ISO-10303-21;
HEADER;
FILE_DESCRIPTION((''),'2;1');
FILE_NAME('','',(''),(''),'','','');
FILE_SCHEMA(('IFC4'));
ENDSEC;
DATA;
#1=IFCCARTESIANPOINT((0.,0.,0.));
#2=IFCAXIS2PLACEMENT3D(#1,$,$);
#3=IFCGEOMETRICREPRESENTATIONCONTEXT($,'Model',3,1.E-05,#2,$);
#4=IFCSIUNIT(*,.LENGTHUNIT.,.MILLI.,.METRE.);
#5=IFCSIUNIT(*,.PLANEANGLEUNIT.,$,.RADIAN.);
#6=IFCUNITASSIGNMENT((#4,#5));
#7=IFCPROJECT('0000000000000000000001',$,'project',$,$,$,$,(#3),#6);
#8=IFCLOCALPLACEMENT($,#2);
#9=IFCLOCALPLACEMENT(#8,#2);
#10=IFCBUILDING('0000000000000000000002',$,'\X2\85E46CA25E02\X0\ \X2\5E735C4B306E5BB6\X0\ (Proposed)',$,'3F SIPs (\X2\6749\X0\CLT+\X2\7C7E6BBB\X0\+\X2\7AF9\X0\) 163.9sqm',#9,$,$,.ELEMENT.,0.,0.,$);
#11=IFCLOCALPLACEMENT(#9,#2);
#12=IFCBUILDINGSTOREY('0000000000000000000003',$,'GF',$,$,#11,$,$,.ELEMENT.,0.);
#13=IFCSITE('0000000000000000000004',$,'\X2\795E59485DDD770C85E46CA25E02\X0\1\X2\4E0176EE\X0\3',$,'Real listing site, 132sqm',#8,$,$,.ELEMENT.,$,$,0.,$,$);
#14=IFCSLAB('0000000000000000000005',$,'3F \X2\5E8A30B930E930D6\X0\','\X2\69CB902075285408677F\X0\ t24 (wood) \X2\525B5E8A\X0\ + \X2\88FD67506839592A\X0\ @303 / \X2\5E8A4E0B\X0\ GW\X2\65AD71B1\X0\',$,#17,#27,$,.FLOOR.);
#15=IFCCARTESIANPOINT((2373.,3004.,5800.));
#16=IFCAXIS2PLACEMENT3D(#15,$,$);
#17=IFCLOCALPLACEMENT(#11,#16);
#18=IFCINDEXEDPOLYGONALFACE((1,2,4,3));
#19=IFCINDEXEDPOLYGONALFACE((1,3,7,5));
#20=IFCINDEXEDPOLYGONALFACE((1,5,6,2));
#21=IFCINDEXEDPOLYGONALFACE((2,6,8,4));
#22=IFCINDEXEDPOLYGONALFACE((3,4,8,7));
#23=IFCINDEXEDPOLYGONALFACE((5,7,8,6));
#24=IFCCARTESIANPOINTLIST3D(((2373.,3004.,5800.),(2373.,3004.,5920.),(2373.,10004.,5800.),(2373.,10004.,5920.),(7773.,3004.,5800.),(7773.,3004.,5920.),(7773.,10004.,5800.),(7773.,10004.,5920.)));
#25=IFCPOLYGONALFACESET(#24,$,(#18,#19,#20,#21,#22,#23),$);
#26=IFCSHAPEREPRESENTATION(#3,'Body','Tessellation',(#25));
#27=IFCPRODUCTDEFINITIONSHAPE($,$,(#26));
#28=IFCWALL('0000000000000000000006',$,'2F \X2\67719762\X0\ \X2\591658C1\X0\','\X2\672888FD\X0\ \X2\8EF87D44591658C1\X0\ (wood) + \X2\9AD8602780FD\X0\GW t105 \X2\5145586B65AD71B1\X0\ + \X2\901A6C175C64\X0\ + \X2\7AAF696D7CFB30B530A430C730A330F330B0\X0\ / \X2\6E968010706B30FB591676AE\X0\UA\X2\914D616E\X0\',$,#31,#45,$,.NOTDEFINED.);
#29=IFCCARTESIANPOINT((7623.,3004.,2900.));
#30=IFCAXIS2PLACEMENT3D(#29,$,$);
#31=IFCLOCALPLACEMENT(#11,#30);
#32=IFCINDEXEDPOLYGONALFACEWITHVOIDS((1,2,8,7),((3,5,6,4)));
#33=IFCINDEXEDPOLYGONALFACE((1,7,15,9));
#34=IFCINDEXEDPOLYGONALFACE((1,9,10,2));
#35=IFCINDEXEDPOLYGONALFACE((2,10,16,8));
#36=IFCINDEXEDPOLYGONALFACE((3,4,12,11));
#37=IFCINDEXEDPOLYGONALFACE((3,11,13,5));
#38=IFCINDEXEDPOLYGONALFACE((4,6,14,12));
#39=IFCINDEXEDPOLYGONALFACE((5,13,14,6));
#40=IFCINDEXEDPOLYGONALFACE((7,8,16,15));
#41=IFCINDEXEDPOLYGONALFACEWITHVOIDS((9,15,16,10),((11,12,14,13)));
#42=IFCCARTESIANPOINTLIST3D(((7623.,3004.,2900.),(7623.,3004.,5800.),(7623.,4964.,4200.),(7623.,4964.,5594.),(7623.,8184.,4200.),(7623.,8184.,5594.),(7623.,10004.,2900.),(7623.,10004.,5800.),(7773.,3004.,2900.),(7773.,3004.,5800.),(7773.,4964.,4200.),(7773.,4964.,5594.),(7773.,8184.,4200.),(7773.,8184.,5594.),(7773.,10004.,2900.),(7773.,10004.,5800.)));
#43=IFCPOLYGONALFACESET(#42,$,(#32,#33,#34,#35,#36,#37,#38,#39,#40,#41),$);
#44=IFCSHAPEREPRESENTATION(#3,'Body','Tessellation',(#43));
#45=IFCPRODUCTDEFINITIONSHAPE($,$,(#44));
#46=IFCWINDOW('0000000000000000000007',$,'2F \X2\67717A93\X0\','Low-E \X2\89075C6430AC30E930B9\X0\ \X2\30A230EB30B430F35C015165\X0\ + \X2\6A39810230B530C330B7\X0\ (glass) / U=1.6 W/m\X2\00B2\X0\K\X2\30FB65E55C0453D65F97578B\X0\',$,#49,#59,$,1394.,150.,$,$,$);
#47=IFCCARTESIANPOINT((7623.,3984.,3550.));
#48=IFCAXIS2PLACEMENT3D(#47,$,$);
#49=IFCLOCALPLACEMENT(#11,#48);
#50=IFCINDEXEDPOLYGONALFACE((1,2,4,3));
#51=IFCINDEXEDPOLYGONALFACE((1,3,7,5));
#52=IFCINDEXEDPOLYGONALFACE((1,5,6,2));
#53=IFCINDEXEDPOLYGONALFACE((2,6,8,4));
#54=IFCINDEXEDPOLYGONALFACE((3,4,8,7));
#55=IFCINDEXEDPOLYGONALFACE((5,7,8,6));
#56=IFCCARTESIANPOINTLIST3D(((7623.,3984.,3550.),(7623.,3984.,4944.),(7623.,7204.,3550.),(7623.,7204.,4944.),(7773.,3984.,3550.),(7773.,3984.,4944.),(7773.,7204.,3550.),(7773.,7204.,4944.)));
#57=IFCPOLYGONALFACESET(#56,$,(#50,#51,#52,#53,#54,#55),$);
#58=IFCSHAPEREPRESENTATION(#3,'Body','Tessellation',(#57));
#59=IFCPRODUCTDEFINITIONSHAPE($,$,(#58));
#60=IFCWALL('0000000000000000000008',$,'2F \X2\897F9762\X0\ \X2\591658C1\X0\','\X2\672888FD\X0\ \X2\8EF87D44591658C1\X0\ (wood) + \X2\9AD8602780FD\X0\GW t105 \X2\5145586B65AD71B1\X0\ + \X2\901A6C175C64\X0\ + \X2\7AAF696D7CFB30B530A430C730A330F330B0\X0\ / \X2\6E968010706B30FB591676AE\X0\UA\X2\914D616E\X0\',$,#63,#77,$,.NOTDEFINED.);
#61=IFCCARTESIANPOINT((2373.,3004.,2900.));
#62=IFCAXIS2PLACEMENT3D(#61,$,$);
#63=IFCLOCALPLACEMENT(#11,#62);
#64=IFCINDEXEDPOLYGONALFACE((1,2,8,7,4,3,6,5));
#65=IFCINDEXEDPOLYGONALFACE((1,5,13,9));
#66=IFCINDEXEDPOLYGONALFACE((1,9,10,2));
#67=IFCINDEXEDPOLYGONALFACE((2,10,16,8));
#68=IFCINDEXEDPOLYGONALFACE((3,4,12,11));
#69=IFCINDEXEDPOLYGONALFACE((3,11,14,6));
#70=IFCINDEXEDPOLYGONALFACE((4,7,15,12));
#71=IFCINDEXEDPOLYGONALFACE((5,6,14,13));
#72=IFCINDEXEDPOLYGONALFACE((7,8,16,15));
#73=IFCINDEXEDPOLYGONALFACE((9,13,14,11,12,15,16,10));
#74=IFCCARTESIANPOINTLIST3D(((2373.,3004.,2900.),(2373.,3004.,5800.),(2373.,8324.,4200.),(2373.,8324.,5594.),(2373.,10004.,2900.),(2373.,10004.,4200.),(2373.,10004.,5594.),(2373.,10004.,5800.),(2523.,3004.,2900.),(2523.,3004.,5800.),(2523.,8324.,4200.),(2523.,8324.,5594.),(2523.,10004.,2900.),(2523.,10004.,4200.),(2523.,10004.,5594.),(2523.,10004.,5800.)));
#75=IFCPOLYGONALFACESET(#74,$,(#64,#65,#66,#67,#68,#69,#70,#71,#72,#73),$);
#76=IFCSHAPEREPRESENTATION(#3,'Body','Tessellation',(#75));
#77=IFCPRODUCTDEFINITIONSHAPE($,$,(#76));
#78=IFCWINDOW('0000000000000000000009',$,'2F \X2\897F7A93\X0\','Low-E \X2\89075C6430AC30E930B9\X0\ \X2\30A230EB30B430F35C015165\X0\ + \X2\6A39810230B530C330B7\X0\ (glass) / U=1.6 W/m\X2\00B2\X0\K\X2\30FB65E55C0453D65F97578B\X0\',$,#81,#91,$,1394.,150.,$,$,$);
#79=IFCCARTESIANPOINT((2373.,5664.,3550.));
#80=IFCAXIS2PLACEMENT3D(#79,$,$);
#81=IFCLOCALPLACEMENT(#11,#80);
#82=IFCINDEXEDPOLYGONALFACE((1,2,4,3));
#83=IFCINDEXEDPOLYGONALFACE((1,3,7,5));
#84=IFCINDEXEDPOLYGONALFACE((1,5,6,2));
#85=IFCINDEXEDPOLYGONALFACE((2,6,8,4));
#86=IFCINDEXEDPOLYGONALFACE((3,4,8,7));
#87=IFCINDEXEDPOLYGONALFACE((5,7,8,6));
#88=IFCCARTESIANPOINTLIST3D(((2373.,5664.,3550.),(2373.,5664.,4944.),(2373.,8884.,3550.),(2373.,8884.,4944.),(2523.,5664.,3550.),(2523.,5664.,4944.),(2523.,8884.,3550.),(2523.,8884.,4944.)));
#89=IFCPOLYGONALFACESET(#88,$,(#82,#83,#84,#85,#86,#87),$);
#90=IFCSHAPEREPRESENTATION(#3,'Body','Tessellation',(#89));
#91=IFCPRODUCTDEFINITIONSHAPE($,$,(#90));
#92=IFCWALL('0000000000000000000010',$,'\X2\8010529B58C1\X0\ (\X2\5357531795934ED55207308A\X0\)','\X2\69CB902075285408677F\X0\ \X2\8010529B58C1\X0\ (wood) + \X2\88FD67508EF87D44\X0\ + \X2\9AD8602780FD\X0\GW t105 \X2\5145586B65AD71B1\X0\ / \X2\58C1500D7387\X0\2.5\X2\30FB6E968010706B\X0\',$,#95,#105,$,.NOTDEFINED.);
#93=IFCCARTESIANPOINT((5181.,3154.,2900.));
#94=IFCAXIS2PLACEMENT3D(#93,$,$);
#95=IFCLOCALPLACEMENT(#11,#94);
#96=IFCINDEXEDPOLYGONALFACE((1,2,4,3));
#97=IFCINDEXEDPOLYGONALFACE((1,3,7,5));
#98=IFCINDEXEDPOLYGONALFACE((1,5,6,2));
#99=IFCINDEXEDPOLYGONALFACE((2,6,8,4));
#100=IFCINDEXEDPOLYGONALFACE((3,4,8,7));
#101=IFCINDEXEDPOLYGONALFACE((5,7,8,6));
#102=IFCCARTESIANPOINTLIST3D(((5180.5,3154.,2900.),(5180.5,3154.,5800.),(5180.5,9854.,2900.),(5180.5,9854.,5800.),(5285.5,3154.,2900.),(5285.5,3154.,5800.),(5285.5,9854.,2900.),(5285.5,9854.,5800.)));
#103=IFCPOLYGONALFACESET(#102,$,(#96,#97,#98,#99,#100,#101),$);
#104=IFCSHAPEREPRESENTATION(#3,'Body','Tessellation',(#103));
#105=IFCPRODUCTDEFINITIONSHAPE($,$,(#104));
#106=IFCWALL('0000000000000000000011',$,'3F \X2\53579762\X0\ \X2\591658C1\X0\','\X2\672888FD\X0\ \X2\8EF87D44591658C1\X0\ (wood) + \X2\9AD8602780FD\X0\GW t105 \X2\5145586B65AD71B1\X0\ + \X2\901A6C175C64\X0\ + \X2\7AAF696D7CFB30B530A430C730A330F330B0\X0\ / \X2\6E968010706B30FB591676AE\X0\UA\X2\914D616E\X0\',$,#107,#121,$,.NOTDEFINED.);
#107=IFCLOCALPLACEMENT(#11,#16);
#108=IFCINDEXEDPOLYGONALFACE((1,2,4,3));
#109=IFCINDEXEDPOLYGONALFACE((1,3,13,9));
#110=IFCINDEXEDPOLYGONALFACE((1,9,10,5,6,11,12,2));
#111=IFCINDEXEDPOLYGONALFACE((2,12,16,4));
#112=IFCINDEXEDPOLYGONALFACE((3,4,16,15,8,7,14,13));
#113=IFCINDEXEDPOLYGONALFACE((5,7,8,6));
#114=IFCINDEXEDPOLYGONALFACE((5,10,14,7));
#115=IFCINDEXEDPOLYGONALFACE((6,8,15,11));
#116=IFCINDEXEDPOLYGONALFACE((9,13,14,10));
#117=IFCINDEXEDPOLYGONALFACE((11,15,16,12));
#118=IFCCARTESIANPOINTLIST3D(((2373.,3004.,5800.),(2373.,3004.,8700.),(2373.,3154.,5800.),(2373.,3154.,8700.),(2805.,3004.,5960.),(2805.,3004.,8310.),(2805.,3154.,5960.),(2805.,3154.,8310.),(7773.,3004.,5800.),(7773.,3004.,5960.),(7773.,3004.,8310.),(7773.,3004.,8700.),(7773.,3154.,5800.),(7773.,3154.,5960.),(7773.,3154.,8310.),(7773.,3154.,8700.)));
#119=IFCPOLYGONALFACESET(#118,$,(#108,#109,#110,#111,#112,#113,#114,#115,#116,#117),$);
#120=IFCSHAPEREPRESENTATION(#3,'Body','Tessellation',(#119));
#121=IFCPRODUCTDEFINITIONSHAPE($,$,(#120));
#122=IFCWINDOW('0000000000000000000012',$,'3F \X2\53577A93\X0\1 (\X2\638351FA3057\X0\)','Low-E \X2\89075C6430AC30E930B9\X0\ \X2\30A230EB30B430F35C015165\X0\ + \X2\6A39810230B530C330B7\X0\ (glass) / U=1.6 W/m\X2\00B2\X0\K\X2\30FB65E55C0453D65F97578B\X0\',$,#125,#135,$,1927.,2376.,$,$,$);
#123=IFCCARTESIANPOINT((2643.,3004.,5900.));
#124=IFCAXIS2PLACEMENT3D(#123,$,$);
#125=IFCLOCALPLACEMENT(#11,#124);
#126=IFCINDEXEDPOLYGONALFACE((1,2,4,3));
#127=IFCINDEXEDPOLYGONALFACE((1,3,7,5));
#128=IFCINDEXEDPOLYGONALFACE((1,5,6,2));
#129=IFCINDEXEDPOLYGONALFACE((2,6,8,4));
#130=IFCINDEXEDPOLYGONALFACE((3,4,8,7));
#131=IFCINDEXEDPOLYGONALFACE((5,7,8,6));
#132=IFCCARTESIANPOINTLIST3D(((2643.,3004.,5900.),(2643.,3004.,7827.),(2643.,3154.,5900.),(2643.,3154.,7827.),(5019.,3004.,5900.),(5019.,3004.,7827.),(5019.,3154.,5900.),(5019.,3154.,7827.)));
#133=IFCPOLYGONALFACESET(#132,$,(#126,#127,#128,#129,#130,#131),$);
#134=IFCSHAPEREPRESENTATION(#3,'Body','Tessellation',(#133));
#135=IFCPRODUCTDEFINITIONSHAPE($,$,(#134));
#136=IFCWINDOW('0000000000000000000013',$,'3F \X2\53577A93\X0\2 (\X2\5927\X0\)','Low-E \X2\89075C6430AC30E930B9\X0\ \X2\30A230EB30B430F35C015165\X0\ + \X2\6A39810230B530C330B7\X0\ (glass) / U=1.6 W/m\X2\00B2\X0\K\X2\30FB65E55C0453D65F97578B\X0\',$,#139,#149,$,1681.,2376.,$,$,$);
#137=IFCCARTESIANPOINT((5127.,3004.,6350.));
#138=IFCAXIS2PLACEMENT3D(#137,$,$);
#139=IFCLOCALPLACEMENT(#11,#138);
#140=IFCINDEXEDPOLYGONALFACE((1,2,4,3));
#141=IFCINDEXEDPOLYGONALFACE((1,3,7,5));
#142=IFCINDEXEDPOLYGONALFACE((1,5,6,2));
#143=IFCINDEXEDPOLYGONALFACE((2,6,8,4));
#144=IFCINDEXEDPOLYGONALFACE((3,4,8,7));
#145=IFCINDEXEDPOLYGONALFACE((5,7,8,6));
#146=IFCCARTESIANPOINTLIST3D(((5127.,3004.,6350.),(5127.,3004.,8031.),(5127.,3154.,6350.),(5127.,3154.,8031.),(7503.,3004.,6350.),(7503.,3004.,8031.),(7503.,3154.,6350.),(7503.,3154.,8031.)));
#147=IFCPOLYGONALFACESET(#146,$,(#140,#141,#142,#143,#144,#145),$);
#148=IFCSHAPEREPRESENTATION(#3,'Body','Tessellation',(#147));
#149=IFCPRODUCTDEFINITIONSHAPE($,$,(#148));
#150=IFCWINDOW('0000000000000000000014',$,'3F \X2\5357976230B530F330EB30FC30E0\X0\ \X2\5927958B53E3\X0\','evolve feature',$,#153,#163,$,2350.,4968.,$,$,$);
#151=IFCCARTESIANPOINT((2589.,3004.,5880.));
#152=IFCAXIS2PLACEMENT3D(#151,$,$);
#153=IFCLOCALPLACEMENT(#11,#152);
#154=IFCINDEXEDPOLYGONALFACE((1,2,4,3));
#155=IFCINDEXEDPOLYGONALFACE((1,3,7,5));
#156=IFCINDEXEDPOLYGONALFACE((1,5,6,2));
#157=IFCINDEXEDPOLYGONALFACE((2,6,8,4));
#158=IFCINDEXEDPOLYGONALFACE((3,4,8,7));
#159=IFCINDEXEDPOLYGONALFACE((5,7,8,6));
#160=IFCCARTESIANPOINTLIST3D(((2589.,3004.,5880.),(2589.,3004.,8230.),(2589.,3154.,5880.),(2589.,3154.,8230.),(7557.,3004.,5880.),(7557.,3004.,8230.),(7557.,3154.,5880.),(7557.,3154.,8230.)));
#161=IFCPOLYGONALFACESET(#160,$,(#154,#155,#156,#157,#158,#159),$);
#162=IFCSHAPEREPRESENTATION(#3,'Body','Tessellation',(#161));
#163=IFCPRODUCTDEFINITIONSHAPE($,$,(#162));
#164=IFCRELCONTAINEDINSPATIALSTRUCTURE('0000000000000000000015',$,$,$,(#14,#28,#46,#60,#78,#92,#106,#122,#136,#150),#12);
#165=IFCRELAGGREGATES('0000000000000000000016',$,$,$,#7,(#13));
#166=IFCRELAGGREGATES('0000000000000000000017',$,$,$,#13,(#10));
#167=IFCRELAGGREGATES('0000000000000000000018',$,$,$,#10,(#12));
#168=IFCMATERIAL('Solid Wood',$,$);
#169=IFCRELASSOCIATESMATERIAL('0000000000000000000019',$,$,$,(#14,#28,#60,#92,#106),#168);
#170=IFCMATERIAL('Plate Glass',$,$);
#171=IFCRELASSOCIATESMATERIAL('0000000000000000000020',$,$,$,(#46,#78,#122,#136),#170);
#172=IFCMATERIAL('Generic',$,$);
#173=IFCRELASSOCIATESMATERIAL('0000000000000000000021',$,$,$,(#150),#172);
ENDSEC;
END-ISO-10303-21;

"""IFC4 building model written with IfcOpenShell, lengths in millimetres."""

from ifc_helpers import new_model, si_unit, frame, frame_2d, origin, place, context, project, spatial, rectangle, extrude, material, element, fill, save


model = new_model("IFC4")

# Units and contexts
model_context = context("Model", 3, precision=1e-05, world=origin())
ifc_project = project(units=[si_unit("LENGTHUNIT", "METRE", prefix="MILLI"), si_unit("PLANEANGLEUNIT", "RADIAN")], contexts=[model_context])

# Site, building, storey
site_placement = place(None, origin())
site = spatial("IfcSite", under=ifc_project, at=site_placement, Name="神奈川県藤沢市1丁目3", ObjectType="Real listing site, 132sqm", CompositionType="ELEMENT", RefElevation=0.0)
building_placement = place(site_placement, origin())
building = spatial("IfcBuilding", under=site, at=building_placement, Name="藤沢市 平屋の家 (Proposed)", ObjectType="3F SIPs (杉CLT+籾殻+竹) 163.9sqm", CompositionType="ELEMENT", ElevationOfRefHeight=0.0, ElevationOfTerrain=0.0)
storey_placement = place(building_placement, origin())
storey = spatial("IfcBuildingStorey", under=building, at=storey_placement, Name="GF", CompositionType="ELEMENT", Elevation=0.0)

# Slab
ifc_material_1 = material(Name="Solid Wood")
slab_placement = place(storey_placement, frame((2373.0, 3004.0, 5800.0)))
element("IfcSlab", 1, at=slab_placement, inside=storey, material=ifc_material_1, Name="3F 床スラブ", Description="構造用合板 t24 (wood) 剛床 + 製材根太 @303 / 床下 GW断熱", PredefinedType="FLOOR", context=model_context, shape_type="SweptSolid", body=[
    extrude(rectangle(XDim=5400.0, YDim=7000.0, at=frame_2d((2700.0, 3500.0))), frame((2373.0, 3004.0, 5800.0)), (0.0, 0.0, 1.0), 120.0),
])

# Walls, openings, windows
wall_1_placement = place(storey_placement, frame((7623.0, 3004.0, 2900.0)))
wall_1 = element("IfcWall", 2, at=wall_1_placement, inside=storey, material=ifc_material_1, Name="2F 東面 外壁", Description="木製 軸組外壁 (wood) + 高性能GW t105 充填断熱 + 通気層 + 窯業系サイディング / 準耐火・外皮UA配慮", PredefinedType="NOTDEFINED", context=model_context, shape_type="SweptSolid", body=[
    extrude(rectangle(XDim=150.0, YDim=7000.0, at=frame_2d((75.0, 3500.0))), frame((7623.0, 3004.0, 2900.0)), (0.0, 0.0, 1.0), 2900.0),
])
opening_1_placement = place(storey_placement, frame((7623.0, 3984.0, 3550.0)))
opening_1 = element("IfcOpeningElement", 3, at=opening_1_placement, cuts=wall_1, PredefinedType="NOTDEFINED", context=model_context, shape_type="SweptSolid", body=[
    extrude(rectangle(XDim=150.0, YDim=3220.0, at=frame_2d((75.0, 1610.0))), frame((7623.0, 3984.0, 3550.0)), (0.0, 0.0, 1.0), 1394.0),
])
ifc_material_2 = material(Name="Plate Glass")
window_1_placement = place(storey_placement, frame((7623.0, 3984.0, 3550.0)))
window_1 = element("IfcWindow", 4, at=window_1_placement, inside=storey, material=ifc_material_2, Name="2F 東窓", Description="Low-E 複層ガラス アルゴン封入 + 樹脂サッシ (glass) / U=1.6 W/m²K・日射取得型", OverallHeight=1394.0, OverallWidth=150.0, context=model_context, shape_type="SweptSolid", body=[
    extrude(rectangle(XDim=150.0, YDim=3220.0, at=frame_2d((75.0, 1610.0))), frame((7623.0, 3984.0, 3550.0)), (0.0, 0.0, 1.0), 1394.0),
])
fill(opening_1, window_1)
wall_2_placement = place(storey_placement, frame((2373.0, 3004.0, 2900.0)))
wall_2 = element("IfcWall", 5, at=wall_2_placement, inside=storey, material=ifc_material_1, Name="2F 西面 外壁", Description="木製 軸組外壁 (wood) + 高性能GW t105 充填断熱 + 通気層 + 窯業系サイディング / 準耐火・外皮UA配慮", PredefinedType="NOTDEFINED", context=model_context, shape_type="SweptSolid", body=[
    extrude(rectangle(XDim=150.0, YDim=7000.0, at=frame_2d((75.0, 3500.0))), frame((2373.0, 3004.0, 2900.0)), (0.0, 0.0, 1.0), 2900.0),
])
opening_2_placement = place(storey_placement, frame((2373.0, 5664.0, 3550.0)))
opening_2 = element("IfcOpeningElement", 6, at=opening_2_placement, cuts=wall_2, PredefinedType="NOTDEFINED", context=model_context, shape_type="SweptSolid", body=[
    extrude(rectangle(XDim=150.0, YDim=3220.0, at=frame_2d((75.0, 1610.0))), frame((2373.0, 5664.0, 3550.0)), (0.0, 0.0, 1.0), 1394.0),
])
window_2_placement = place(storey_placement, frame((2373.0, 5664.0, 3550.0)))
window_2 = element("IfcWindow", 7, at=window_2_placement, inside=storey, material=ifc_material_2, Name="2F 西窓", Description="Low-E 複層ガラス アルゴン封入 + 樹脂サッシ (glass) / U=1.6 W/m²K・日射取得型", OverallHeight=1394.0, OverallWidth=150.0, context=model_context, shape_type="SweptSolid", body=[
    extrude(rectangle(XDim=150.0, YDim=3220.0, at=frame_2d((75.0, 1610.0))), frame((2373.0, 5664.0, 3550.0)), (0.0, 0.0, 1.0), 1394.0),
])
fill(opening_2, window_2)

# Wall
wall_3_placement = place(storey_placement, frame((5181.0, 3154.0, 2900.0)))
element("IfcWall", 8, at=wall_3_placement, inside=storey, material=ifc_material_1, Name="耐力壁 (南北間仕切り)", Description="構造用合板 耐力壁 (wood) + 製材軸組 + 高性能GW t105 充填断熱 / 壁倍率2.5・準耐火", PredefinedType="NOTDEFINED", context=model_context, shape_type="SweptSolid", body=[
    extrude(rectangle(XDim=105.0, YDim=6700.0, at=frame_2d((52.0, 3350.0))), frame((5181.0, 3154.0, 2900.0)), (0.0, 0.0, 1.0), 2900.0),
])

# Wall, openings, windows
wall_4_placement = place(storey_placement, frame((2373.0, 3004.0, 5800.0)))
wall_4 = element("IfcWall", 9, at=wall_4_placement, inside=storey, material=ifc_material_1, Name="3F 南面 外壁", Description="木製 軸組外壁 (wood) + 高性能GW t105 充填断熱 + 通気層 + 窯業系サイディング / 準耐火・外皮UA配慮", PredefinedType="NOTDEFINED", context=model_context, shape_type="SweptSolid", body=[
    extrude(rectangle(XDim=5400.0, YDim=150.0, at=frame_2d((2700.0, 75.0))), frame((2373.0, 3004.0, 5800.0)), (0.0, 0.0, 1.0), 2900.0),
])
opening_3_placement = place(storey_placement, frame((2643.0, 3004.0, 5900.0)))
opening_3 = element("IfcOpeningElement", 10, at=opening_3_placement, cuts=wall_4, PredefinedType="NOTDEFINED", context=model_context, shape_type="SweptSolid", body=[
    extrude(rectangle(XDim=2376.0, YDim=150.0, at=frame_2d((1188.0, 75.0))), frame((2643.0, 3004.0, 5900.0)), (0.0, 0.0, 1.0), 1927.0),
])
opening_4_placement = place(storey_placement, frame((5127.0, 3004.0, 6350.0)))
opening_4 = element("IfcOpeningElement", 11, at=opening_4_placement, cuts=wall_4, PredefinedType="NOTDEFINED", context=model_context, shape_type="SweptSolid", body=[
    extrude(rectangle(XDim=2376.0, YDim=150.0, at=frame_2d((1188.0, 75.0))), frame((5127.0, 3004.0, 6350.0)), (0.0, 0.0, 1.0), 1681.0),
])
opening_5_placement = place(storey_placement, frame((2589.0, 3004.0, 5880.0)))
opening_5 = element("IfcOpeningElement", 12, at=opening_5_placement, cuts=wall_4, PredefinedType="NOTDEFINED", context=model_context, shape_type="SweptSolid", body=[
    extrude(rectangle(XDim=4968.0, YDim=150.0, at=frame_2d((2484.0, 75.0))), frame((2589.0, 3004.0, 5880.0)), (0.0, 0.0, 1.0), 2350.0),
])
window_3_placement = place(storey_placement, frame((2643.0, 3004.0, 5900.0)))
window_3 = element("IfcWindow", 13, at=window_3_placement, inside=storey, material=ifc_material_2, Name="3F 南窓1 (掃出し)", Description="Low-E 複層ガラス アルゴン封入 + 樹脂サッシ (glass) / U=1.6 W/m²K・日射取得型", OverallHeight=1927.0, OverallWidth=2376.0, context=model_context, shape_type="SweptSolid", body=[
    extrude(rectangle(XDim=2376.0, YDim=150.0, at=frame_2d((1188.0, 75.0))), frame((2643.0, 3004.0, 5900.0)), (0.0, 0.0, 1.0), 1927.0),
])
fill(opening_3, window_3)
window_4_placement = place(storey_placement, frame((5127.0, 3004.0, 6350.0)))
window_4 = element("IfcWindow", 14, at=window_4_placement, inside=storey, material=ifc_material_2, Name="3F 南窓2 (大)", Description="Low-E 複層ガラス アルゴン封入 + 樹脂サッシ (glass) / U=1.6 W/m²K・日射取得型", OverallHeight=1681.0, OverallWidth=2376.0, context=model_context, shape_type="SweptSolid", body=[
    extrude(rectangle(XDim=2376.0, YDim=150.0, at=frame_2d((1188.0, 75.0))), frame((5127.0, 3004.0, 6350.0)), (0.0, 0.0, 1.0), 1681.0),
])
fill(opening_4, window_4)
ifc_material_3 = material(Name="Generic")
window_5_placement = place(storey_placement, frame((2589.0, 3004.0, 5880.0)))
window_5 = element("IfcWindow", 15, at=window_5_placement, inside=storey, material=ifc_material_3, Name="3F 南面サンルーム 大開口", Description="evolve feature", OverallHeight=2350.0, OverallWidth=4968.0, context=model_context, shape_type="SweptSolid", body=[
    extrude(rectangle(XDim=4968.0, YDim=150.0, at=frame_2d((2484.0, 75.0))), frame((2589.0, 3004.0, 5880.0)), (0.0, 0.0, 1.0), 2350.0),
])
fill(opening_5, window_5)

save(model, "model.ifc")
